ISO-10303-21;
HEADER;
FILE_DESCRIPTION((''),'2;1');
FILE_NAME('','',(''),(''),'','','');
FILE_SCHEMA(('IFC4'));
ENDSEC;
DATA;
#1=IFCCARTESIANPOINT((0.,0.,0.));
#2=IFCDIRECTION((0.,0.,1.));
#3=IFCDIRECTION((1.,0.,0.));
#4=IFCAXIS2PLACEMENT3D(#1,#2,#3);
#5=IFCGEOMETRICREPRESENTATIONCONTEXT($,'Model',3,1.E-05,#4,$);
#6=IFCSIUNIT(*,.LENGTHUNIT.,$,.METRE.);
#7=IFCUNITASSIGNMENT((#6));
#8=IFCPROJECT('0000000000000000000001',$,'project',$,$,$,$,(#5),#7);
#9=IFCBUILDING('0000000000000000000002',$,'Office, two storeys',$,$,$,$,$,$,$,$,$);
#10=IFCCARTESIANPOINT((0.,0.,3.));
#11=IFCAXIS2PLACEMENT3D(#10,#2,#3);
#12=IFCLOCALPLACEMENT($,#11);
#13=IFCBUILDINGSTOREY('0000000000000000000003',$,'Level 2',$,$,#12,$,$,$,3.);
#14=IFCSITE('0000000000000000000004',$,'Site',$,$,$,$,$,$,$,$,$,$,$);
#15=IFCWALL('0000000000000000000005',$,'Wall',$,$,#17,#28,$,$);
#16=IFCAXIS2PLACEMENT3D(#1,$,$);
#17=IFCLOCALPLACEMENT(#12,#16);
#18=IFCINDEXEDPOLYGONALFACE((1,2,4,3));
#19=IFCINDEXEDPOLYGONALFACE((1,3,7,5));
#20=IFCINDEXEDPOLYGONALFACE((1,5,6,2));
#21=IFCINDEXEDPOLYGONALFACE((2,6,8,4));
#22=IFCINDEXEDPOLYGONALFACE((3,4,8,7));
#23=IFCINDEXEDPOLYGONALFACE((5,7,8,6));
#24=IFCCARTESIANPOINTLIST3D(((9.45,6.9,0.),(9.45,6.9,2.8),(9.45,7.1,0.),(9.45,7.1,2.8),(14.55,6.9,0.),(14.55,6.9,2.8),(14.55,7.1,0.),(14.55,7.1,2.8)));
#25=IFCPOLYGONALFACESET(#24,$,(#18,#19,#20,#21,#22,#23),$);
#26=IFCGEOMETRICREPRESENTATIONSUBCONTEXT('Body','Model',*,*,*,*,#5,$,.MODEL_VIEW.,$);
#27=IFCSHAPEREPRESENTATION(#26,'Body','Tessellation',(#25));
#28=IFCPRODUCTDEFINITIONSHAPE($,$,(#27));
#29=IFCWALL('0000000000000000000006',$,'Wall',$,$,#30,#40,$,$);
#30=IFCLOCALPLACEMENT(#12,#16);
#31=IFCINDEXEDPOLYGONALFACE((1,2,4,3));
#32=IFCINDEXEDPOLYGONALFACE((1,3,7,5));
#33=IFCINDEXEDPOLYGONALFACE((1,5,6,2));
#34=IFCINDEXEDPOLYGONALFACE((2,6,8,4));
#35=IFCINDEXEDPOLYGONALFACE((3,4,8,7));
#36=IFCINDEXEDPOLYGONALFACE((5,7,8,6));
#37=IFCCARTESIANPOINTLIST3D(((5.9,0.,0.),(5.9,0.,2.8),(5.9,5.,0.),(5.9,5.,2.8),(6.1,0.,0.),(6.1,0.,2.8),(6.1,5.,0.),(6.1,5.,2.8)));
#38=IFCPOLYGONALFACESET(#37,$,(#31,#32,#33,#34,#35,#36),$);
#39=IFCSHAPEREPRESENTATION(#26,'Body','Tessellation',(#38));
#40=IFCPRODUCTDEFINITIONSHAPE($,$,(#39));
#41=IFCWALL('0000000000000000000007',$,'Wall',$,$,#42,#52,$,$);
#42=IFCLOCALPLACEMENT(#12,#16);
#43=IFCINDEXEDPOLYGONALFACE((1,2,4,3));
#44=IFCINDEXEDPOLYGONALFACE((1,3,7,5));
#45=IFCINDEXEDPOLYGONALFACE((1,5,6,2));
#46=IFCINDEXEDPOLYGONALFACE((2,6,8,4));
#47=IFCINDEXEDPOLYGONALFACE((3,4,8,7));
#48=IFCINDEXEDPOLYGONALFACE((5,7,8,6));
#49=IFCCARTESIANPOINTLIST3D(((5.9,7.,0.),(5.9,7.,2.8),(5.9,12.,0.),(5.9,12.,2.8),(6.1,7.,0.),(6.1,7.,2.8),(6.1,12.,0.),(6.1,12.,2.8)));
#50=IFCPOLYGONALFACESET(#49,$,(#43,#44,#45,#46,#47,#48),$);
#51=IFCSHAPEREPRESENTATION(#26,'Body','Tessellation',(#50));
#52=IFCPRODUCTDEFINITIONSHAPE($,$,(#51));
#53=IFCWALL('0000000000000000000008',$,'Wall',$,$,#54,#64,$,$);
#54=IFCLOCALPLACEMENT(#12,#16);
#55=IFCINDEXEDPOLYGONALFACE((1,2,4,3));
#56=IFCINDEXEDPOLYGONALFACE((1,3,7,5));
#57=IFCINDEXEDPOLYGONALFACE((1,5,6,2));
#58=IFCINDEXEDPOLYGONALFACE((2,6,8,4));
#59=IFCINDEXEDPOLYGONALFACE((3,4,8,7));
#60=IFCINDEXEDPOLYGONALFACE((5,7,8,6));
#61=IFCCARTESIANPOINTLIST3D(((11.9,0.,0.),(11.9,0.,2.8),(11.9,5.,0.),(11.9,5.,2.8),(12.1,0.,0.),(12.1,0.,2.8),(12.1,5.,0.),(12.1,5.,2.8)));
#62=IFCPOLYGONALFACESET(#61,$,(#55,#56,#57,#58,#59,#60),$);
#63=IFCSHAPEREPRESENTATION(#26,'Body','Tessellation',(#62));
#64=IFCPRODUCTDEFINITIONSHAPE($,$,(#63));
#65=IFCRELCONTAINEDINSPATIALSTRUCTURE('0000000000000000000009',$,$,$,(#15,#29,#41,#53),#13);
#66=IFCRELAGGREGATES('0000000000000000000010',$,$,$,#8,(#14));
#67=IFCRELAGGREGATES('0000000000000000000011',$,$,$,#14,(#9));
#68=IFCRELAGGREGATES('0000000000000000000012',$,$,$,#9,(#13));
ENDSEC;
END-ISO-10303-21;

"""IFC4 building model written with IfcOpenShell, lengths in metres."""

from ifc_helpers import new_model, si_unit, frame, origin_with_axes, place, context, subcontext, project, spatial, indexed_curve, outline, extrude, element, save


model = new_model("IFC4")

# Units and contexts
model_context = context("Model", 3, precision=1e-05, world=origin_with_axes())
body_context = subcontext(model_context, "Body", "Model", "MODEL_VIEW")
ifc_project = project(units=[si_unit("LENGTHUNIT", "METRE")], contexts=[model_context])

# Site, building, storey
site = spatial("IfcSite", under=ifc_project, Name="Site")
building = spatial("IfcBuilding", under=site, Name="Office, two storeys")
storey_placement = place(None, frame((0.0, 0.0, 3.0), z_axis=(0.0, 0.0, 1.0), x_axis=(1.0, 0.0, 0.0)))
storey = spatial("IfcBuildingStorey", under=building, at=storey_placement, Name="Level 2", Elevation=3.0)

# Walls
wall_1_placement = place(storey_placement, frame((9.45, 7.0, 0.0), z_axis=(0.0, 0.0, 1.0), x_axis=(1.0, 0.0, 0.0)))
element("IfcWall", 1, at=wall_1_placement, inside=storey, Name="Wall", context=body_context, shape_type="SweptSolid", body=[
    extrude(outline(indexed_curve([(0.0, 0.0), (0.0, 0.2), (5.1, 0.2), (5.1, 0.0), (0.0, 0.0)], self_intersect=False)), frame((0.0, -0.1, 0.0), z_axis=(0.0, 0.0, 1.0), x_axis=(1.0, 0.0, 0.0)), (0.0, 0.0, 1.0), 2.8),
])
for number, where, z_axis, x_axis, name in (
    (2, (6.0, 0.0, 0.0), (0.0, 0.0, 1.0), (0.0, 1.0, 0.0), "Wall"),
    (3, (6.0, 7.0, 0.0), (0.0, 0.0, 1.0), (0.0, 1.0, 0.0), "Wall"),
    (4, (12.0, 0.0, 0.0), (0.0, 0.0, 1.0), (0.0, 1.0, 0.0), "Wall"),
):
    element("IfcWall", number, at=place(storey_placement, frame(where, z_axis=z_axis, x_axis=x_axis)), inside=storey, Name=name, context=body_context, shape_type="SweptSolid", body=[
        extrude(outline(indexed_curve([(0.0, 0.0), (0.0, 0.2), (5.0, 0.2), (5.0, 0.0), (0.0, 0.0)], self_intersect=False)), frame((0.0, -0.1, 0.0), z_axis=(0.0, 0.0, 1.0), x_axis=(1.0, 0.0, 0.0)), (0.0, 0.0, 1.0), 2.8),
    ])

save(model, "model.ifc")
